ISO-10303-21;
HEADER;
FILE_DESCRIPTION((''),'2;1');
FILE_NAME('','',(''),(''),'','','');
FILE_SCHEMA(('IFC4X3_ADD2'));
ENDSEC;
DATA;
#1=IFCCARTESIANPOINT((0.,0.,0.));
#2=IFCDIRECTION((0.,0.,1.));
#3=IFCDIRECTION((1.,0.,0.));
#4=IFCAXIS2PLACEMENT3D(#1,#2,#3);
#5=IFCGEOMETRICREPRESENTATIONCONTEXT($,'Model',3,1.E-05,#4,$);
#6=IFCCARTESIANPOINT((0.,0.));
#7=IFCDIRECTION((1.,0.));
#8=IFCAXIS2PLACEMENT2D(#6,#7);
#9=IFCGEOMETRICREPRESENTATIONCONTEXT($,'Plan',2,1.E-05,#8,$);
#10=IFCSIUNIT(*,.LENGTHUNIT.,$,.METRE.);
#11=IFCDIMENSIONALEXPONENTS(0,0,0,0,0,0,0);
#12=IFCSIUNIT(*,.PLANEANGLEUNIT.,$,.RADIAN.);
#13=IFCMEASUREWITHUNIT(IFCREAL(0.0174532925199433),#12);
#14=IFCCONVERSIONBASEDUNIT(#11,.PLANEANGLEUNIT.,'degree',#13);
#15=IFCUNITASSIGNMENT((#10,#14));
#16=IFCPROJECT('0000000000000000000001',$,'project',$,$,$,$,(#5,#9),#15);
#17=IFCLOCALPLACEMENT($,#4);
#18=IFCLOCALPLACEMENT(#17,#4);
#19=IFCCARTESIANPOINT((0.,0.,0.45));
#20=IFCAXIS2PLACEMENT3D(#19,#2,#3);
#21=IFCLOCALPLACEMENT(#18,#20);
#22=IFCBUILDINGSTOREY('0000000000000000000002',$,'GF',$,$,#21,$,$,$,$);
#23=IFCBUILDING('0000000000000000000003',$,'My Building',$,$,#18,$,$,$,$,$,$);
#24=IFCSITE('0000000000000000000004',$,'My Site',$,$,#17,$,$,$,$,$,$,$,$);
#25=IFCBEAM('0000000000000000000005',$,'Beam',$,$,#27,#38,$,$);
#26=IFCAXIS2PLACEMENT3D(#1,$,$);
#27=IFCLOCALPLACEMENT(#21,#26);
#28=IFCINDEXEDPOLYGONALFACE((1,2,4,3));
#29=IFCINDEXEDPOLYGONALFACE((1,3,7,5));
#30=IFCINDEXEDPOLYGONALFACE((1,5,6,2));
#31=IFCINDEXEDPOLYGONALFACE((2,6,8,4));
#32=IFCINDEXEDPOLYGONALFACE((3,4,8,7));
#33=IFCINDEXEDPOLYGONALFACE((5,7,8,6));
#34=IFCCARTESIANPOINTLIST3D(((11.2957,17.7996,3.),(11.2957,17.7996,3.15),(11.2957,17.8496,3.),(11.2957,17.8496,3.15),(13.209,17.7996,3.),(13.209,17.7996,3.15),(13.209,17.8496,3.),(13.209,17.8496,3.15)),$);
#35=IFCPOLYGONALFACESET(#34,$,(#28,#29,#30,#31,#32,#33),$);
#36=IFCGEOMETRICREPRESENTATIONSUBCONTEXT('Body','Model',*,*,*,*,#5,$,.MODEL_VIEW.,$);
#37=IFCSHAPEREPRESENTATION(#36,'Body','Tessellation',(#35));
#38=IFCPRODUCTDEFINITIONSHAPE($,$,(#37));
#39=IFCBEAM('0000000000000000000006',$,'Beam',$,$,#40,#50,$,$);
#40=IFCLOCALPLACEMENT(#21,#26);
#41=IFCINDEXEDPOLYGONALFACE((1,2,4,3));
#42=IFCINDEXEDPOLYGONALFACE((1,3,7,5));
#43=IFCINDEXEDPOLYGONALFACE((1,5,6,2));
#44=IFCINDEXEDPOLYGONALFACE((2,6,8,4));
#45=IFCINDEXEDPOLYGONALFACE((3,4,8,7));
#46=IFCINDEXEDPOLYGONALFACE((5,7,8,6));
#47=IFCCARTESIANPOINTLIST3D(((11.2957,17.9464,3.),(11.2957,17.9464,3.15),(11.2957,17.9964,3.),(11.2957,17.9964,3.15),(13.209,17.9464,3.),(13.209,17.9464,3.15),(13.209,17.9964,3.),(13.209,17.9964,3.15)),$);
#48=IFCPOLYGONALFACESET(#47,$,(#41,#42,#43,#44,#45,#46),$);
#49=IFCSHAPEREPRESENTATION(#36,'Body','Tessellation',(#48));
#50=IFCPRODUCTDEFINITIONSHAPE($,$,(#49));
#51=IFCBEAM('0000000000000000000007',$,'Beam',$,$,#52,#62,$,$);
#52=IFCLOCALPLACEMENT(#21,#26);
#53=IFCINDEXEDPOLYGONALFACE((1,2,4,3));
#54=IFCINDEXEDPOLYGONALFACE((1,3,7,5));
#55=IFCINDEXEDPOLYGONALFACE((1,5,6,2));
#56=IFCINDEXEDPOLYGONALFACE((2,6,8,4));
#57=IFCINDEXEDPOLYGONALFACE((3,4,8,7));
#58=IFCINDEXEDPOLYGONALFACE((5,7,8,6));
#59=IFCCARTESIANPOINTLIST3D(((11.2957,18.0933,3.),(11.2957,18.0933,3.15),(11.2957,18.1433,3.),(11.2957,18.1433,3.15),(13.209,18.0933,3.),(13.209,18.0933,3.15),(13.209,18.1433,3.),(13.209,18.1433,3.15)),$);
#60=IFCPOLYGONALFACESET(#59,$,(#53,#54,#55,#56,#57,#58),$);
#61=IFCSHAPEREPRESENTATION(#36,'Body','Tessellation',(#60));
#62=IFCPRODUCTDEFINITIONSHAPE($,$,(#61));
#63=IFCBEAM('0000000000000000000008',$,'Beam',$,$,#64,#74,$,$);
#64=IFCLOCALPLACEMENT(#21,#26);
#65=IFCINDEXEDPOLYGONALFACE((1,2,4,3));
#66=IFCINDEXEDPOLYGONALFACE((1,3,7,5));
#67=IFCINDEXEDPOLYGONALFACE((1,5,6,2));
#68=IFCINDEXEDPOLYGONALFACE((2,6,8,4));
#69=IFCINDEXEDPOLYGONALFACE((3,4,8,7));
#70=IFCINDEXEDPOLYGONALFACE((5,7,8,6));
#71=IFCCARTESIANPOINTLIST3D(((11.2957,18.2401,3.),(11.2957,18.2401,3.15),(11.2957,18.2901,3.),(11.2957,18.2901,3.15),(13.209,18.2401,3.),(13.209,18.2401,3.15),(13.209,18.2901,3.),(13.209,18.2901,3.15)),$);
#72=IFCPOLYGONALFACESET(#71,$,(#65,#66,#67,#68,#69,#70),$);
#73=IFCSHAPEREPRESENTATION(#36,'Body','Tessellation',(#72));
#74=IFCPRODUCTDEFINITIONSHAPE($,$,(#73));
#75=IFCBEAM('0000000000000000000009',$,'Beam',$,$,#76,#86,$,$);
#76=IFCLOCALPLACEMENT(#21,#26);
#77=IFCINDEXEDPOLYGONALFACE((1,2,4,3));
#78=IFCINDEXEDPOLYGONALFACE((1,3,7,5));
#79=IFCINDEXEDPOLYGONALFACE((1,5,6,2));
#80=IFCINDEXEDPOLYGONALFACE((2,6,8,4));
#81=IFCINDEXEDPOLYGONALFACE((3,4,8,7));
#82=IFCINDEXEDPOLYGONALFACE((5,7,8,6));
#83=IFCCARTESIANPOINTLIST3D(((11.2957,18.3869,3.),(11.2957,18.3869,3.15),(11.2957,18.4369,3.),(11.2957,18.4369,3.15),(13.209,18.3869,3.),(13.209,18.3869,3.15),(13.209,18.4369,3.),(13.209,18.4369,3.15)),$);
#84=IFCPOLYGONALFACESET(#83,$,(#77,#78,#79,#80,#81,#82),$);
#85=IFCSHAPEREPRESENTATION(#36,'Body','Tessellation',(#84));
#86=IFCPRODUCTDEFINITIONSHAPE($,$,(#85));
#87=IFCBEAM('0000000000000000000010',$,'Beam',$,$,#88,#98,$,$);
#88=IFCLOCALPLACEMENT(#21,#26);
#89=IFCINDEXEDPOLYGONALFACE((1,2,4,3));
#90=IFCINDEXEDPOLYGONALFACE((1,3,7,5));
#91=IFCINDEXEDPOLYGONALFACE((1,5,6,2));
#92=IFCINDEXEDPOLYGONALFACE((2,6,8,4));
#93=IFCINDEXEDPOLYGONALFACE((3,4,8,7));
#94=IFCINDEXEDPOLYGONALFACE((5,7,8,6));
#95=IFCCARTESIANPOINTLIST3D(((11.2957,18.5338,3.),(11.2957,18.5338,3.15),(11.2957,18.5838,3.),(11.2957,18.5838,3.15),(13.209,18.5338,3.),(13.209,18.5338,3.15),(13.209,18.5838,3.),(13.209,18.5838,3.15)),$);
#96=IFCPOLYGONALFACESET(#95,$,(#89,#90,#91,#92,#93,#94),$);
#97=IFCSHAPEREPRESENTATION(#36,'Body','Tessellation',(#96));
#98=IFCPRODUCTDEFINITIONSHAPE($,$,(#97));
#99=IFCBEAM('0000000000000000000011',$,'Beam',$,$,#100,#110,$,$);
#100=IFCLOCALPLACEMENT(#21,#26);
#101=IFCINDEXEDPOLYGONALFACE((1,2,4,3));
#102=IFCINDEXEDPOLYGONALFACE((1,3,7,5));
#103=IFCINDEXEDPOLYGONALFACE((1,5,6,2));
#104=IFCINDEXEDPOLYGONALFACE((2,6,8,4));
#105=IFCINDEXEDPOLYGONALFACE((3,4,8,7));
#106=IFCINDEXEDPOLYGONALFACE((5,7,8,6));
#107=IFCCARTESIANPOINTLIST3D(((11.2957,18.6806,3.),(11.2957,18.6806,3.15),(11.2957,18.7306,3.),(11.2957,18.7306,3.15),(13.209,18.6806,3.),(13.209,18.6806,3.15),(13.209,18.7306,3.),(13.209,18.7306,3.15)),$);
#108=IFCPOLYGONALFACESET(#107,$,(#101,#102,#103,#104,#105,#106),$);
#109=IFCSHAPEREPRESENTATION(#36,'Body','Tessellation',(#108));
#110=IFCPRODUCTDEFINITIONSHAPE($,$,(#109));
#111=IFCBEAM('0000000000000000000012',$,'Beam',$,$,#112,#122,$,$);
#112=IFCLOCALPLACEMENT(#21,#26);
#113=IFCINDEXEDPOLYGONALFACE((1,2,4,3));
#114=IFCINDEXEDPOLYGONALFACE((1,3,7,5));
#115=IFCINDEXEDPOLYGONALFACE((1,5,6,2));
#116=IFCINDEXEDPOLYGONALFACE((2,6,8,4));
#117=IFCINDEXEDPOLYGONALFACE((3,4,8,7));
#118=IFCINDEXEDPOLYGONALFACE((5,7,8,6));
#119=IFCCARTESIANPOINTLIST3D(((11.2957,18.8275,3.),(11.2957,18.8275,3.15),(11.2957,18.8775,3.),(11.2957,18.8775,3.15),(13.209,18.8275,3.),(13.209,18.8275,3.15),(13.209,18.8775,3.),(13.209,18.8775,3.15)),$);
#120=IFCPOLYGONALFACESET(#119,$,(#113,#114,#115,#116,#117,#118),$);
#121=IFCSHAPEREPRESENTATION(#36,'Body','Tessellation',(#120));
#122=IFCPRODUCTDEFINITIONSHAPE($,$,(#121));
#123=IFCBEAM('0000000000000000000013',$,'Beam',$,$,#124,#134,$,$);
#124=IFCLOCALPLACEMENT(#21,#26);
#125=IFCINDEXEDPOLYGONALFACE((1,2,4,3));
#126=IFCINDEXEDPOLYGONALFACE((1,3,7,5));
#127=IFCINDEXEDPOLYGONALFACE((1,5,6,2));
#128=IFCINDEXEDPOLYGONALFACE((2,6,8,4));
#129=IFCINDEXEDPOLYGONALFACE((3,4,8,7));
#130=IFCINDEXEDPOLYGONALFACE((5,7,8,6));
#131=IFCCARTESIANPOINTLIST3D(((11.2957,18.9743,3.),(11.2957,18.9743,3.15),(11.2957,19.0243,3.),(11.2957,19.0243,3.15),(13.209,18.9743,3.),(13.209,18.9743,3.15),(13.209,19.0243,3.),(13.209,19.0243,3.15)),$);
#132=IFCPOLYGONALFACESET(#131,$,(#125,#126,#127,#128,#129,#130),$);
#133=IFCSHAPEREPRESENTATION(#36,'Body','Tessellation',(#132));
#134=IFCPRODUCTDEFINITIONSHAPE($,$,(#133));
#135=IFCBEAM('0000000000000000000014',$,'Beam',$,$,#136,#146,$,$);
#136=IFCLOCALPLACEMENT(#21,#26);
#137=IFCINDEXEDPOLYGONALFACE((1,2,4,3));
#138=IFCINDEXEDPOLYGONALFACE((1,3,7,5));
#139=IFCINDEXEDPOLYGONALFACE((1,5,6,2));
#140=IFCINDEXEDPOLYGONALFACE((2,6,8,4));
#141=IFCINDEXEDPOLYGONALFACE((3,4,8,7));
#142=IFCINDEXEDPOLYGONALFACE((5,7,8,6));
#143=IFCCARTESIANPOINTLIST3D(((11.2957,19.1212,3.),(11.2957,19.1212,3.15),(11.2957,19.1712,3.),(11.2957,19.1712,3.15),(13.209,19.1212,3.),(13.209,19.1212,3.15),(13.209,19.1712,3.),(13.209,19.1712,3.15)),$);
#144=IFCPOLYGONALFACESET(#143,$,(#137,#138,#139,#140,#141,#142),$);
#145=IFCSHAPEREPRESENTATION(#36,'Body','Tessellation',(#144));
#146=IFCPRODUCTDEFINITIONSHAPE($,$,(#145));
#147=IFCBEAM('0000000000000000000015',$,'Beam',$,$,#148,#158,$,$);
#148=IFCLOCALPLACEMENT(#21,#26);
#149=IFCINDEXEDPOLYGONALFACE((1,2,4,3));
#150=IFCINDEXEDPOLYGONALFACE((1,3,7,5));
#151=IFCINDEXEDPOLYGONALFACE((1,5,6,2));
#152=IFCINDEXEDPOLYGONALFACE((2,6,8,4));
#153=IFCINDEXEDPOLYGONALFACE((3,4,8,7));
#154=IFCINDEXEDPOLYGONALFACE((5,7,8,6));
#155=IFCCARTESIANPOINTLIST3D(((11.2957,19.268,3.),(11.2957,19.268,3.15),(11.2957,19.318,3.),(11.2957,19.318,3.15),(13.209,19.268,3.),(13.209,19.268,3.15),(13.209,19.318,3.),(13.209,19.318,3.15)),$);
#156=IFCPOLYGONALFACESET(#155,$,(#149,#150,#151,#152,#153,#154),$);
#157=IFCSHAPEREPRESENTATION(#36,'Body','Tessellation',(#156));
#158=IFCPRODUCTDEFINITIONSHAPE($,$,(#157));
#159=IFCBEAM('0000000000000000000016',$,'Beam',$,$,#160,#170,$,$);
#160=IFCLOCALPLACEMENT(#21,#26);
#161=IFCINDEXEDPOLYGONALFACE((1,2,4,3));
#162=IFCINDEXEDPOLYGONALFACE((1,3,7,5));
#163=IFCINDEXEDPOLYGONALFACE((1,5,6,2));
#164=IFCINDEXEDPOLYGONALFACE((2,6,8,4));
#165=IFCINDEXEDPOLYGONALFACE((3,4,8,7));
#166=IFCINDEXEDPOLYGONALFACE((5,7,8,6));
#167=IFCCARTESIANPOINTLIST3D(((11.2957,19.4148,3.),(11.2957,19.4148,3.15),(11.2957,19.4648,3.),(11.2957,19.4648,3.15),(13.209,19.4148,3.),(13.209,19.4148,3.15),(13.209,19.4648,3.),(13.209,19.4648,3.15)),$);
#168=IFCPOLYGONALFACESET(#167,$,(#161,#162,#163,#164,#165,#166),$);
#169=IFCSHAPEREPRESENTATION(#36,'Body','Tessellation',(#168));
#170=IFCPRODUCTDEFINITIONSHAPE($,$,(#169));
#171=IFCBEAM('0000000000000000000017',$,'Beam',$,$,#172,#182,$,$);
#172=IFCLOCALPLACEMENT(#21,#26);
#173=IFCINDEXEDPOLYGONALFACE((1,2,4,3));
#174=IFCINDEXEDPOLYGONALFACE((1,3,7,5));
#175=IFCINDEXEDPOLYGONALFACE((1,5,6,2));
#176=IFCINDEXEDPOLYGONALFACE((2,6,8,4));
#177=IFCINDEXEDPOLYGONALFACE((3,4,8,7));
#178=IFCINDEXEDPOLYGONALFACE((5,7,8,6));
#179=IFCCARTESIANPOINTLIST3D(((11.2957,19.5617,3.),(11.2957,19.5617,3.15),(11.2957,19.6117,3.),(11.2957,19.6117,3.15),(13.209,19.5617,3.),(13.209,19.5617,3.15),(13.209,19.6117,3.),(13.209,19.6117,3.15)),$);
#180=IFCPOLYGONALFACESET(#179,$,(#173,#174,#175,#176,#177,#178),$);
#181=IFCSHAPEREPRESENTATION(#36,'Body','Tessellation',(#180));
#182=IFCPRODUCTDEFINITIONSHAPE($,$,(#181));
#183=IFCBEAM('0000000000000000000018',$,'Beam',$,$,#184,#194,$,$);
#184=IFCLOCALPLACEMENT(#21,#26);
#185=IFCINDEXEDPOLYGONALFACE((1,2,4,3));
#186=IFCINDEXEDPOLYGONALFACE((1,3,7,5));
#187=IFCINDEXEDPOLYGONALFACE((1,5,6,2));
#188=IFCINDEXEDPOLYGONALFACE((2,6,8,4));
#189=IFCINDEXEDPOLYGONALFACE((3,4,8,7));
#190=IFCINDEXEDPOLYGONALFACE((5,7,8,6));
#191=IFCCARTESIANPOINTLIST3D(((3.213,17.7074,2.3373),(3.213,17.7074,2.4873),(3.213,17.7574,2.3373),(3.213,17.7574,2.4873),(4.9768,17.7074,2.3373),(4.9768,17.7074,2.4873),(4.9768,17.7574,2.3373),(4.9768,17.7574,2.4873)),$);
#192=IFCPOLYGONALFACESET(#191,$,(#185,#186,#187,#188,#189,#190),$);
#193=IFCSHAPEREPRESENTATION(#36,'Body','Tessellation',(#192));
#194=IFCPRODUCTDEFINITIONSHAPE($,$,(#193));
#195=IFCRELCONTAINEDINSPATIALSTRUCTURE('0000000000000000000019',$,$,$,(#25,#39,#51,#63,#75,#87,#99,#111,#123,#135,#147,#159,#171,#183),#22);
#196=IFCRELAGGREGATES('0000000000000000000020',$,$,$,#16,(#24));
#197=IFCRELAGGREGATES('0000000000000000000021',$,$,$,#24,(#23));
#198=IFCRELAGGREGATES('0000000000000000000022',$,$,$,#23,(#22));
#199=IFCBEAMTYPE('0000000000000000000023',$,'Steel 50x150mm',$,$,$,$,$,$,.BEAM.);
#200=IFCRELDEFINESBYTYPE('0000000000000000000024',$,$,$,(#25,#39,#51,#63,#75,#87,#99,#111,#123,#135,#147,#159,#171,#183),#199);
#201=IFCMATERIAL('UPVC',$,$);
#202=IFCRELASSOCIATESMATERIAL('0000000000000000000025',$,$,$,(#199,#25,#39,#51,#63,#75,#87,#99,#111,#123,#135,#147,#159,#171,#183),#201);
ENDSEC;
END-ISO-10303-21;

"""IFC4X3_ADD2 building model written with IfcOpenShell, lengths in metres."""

from ifc_helpers import new_model, entity, si_unit, converted_unit, frame, origin_with_axes, origin_2d_with_axis, place, context, subcontext, project, spatial, rectangle, extrude, material, material_profile, profile_set, profile_usage, type_object, element, save


model = new_model("IFC4X3_ADD2")

# Units and contexts
model_context = context("Model", 3, precision=1e-05, world=origin_with_axes())
plan_context = context("Plan", 2, precision=1e-05, world=origin_2d_with_axis())
body_context = subcontext(model_context, "Body", "Model", "MODEL_VIEW")
ifc_project = project(units=[si_unit("LENGTHUNIT", "METRE"), converted_unit("PLANEANGLEUNIT", "degree", entity("IfcReal", 0.0174532925199433), si_unit("PLANEANGLEUNIT", "RADIAN"), dimensions=[0, 0, 0, 0, 0, 0, 0])], contexts=[model_context, plan_context])

# Site, building, storey
site_placement = place(None, origin_with_axes())
site = spatial("IfcSite", under=ifc_project, at=site_placement, Name="My Site")
building_placement = place(site_placement, origin_with_axes())
building = spatial("IfcBuilding", under=site, at=building_placement, Name="My Building")
storey_placement = place(building_placement, frame((0.0, 0.0, 0.45), z_axis=(0.0, 0.0, 1.0), x_axis=(1.0, 0.0, 0.0)))
storey = spatial("IfcBuildingStorey", under=building, at=storey_placement, Name="GF")

# Beams
ifc_material_1 = material(Name="UPVC")
ifc_material_profile = material_profile(ifc_material_1, rectangle(XDim=0.05, YDim=0.15))
ifc_profile_set = profile_set([ifc_material_profile])
ifc_profile_usage_1 = profile_usage(ifc_profile_set)
beam_type = type_object("IfcBeamType", Name="Steel 50x150mm", PredefinedType="BEAM", material=ifc_profile_set)
beam_1_placement = place(storey_placement, frame((11.2957, 17.8246, 3.075), z_axis=(1.0, 0.0, 0.0), x_axis=(0.0, 1.0, 0.0)))
element("IfcBeam", 1, at=beam_1_placement, inside=storey, type_object=beam_type, material=ifc_profile_usage_1, Name="Beam", context=body_context, shape_type="SweptSolid", body=[
    extrude(rectangle(XDim=0.05, YDim=0.15), origin_with_axes(), (0.0, 0.0, 1.0), 1.9133),
])
ifc_profile_usage_2 = profile_usage(ifc_profile_set)
beam_2_placement = place(storey_placement, frame((11.2957, 17.9714, 3.075), z_axis=(1.0, 0.0, 0.0), x_axis=(0.0, 1.0, 0.0)))
element("IfcBeam", 2, at=beam_2_placement, inside=storey, type_object=beam_type, material=ifc_profile_usage_2, Name="Beam", context=body_context, shape_type="SweptSolid", body=[
    extrude(rectangle(XDim=0.05, YDim=0.15), origin_with_axes(), (0.0, 0.0, 1.0), 1.9133),
])
ifc_profile_usage_3 = profile_usage(ifc_profile_set)
beam_3_placement = place(storey_placement, frame((11.2957, 18.1183, 3.075), z_axis=(1.0, 0.0, 0.0), x_axis=(0.0, 1.0, 0.0)))
element("IfcBeam", 3, at=beam_3_placement, inside=storey, type_object=beam_type, material=ifc_profile_usage_3, Name="Beam", context=body_context, shape_type="SweptSolid", body=[
    extrude(rectangle(XDim=0.05, YDim=0.15), origin_with_axes(), (0.0, 0.0, 1.0), 1.9133),
])
ifc_profile_usage_4 = profile_usage(ifc_profile_set)
beam_4_placement = place(storey_placement, frame((11.2957, 18.2651, 3.075), z_axis=(1.0, 0.0, 0.0), x_axis=(0.0, 1.0, 0.0)))
element("IfcBeam", 4, at=beam_4_placement, inside=storey, type_object=beam_type, material=ifc_profile_usage_4, Name="Beam", context=body_context, shape_type="SweptSolid", body=[
    extrude(rectangle(XDim=0.05, YDim=0.15), origin_with_axes(), (0.0, 0.0, 1.0), 1.9133),
])
ifc_profile_usage_5 = profile_usage(ifc_profile_set)
beam_5_placement = place(storey_placement, frame((11.2957, 18.4119, 3.075), z_axis=(1.0, 0.0, 0.0), x_axis=(0.0, 1.0, 0.0)))
element("IfcBeam", 5, at=beam_5_placement, inside=storey, type_object=beam_type, material=ifc_profile_usage_5, Name="Beam", context=body_context, shape_type="SweptSolid", body=[
    extrude(rectangle(XDim=0.05, YDim=0.15), origin_with_axes(), (0.0, 0.0, 1.0), 1.9133),
])
ifc_profile_usage_6 = profile_usage(ifc_profile_set)
beam_6_placement = place(storey_placement, frame((11.2957, 18.5588, 3.075), z_axis=(1.0, 0.0, 0.0), x_axis=(0.0, 1.0, 0.0)))
element("IfcBeam", 6, at=beam_6_placement, inside=storey, type_object=beam_type, material=ifc_profile_usage_6, Name="Beam", context=body_context, shape_type="SweptSolid", body=[
    extrude(rectangle(XDim=0.05, YDim=0.15), origin_with_axes(), (0.0, 0.0, 1.0), 1.9133),
])
ifc_profile_usage_7 = profile_usage(ifc_profile_set)
beam_7_placement = place(storey_placement, frame((11.2957, 18.7056, 3.075), z_axis=(1.0, 0.0, 0.0), x_axis=(0.0, 1.0, 0.0)))
element("IfcBeam", 7, at=beam_7_placement, inside=storey, type_object=beam_type, material=ifc_profile_usage_7, Name="Beam", context=body_context, shape_type="SweptSolid", body=[
    extrude(rectangle(XDim=0.05, YDim=0.15), origin_with_axes(), (0.0, 0.0, 1.0), 1.9133),
])
ifc_profile_usage_8 = profile_usage(ifc_profile_set)
beam_8_placement = place(storey_placement, frame((11.2957, 18.8525, 3.075), z_axis=(1.0, 0.0, 0.0), x_axis=(0.0, 1.0, 0.0)))
element("IfcBeam", 8, at=beam_8_placement, inside=storey, type_object=beam_type, material=ifc_profile_usage_8, Name="Beam", context=body_context, shape_type="SweptSolid", body=[
    extrude(rectangle(XDim=0.05, YDim=0.15), origin_with_axes(), (0.0, 0.0, 1.0), 1.9133),
])
ifc_profile_usage_9 = profile_usage(ifc_profile_set)
beam_9_placement = place(storey_placement, frame((11.2957, 18.9993, 3.075), z_axis=(1.0, 0.0, 0.0), x_axis=(0.0, 1.0, 0.0)))
element("IfcBeam", 9, at=beam_9_placement, inside=storey, type_object=beam_type, material=ifc_profile_usage_9, Name="Beam", context=body_context, shape_type="SweptSolid", body=[
    extrude(rectangle(XDim=0.05, YDim=0.15), origin_with_axes(), (0.0, 0.0, 1.0), 1.9133),
])
ifc_profile_usage_10 = profile_usage(ifc_profile_set)
beam_10_placement = place(storey_placement, frame((11.2957, 19.1462, 3.075), z_axis=(1.0, 0.0, 0.0), x_axis=(0.0, 1.0, 0.0)))
element("IfcBeam", 10, at=beam_10_placement, inside=storey, type_object=beam_type, material=ifc_profile_usage_10, Name="Beam", context=body_context, shape_type="SweptSolid", body=[
    extrude(rectangle(XDim=0.05, YDim=0.15), origin_with_axes(), (0.0, 0.0, 1.0), 1.9133),
])
ifc_profile_usage_11 = profile_usage(ifc_profile_set)
beam_11_placement = place(storey_placement, frame((11.2957, 19.293, 3.075), z_axis=(1.0, 0.0, 0.0), x_axis=(0.0, 1.0, 0.0)))
element("IfcBeam", 11, at=beam_11_placement, inside=storey, type_object=beam_type, material=ifc_profile_usage_11, Name="Beam", context=body_context, shape_type="SweptSolid", body=[
    extrude(rectangle(XDim=0.05, YDim=0.15), origin_with_axes(), (0.0, 0.0, 1.0), 1.9133),
])
ifc_profile_usage_12 = profile_usage(ifc_profile_set)
beam_12_placement = place(storey_placement, frame((11.2957, 19.4398, 3.075), z_axis=(1.0, 0.0, 0.0), x_axis=(0.0, 1.0, 0.0)))
element("IfcBeam", 12, at=beam_12_placement, inside=storey, type_object=beam_type, material=ifc_profile_usage_12, Name="Beam", context=body_context, shape_type="SweptSolid", body=[
    extrude(rectangle(XDim=0.05, YDim=0.15), origin_with_axes(), (0.0, 0.0, 1.0), 1.9133),
])
ifc_profile_usage_13 = profile_usage(ifc_profile_set)
beam_13_placement = place(storey_placement, frame((11.2957, 19.5867, 3.075), z_axis=(1.0, 0.0, 0.0), x_axis=(0.0, 1.0, 0.0)))
element("IfcBeam", 13, at=beam_13_placement, inside=storey, type_object=beam_type, material=ifc_profile_usage_13, Name="Beam", context=body_context, shape_type="SweptSolid", body=[
    extrude(rectangle(XDim=0.05, YDim=0.15), origin_with_axes(), (0.0, 0.0, 1.0), 1.9133),
])
ifc_profile_usage_14 = profile_usage(ifc_profile_set)
beam_14_placement = place(storey_placement, frame((3.213, 17.7324, 2.4123), z_axis=(1.0, 0.0, 0.0), x_axis=(0.0, 1.0, 0.0)))
element("IfcBeam", 14, at=beam_14_placement, inside=storey, type_object=beam_type, material=ifc_profile_usage_14, Name="Beam", context=body_context, shape_type="SweptSolid", body=[
    extrude(rectangle(XDim=0.05, YDim=0.15), origin_with_axes(), (0.0, 0.0, 1.0), 1.7638),
])

save(model, "model.ifc")
